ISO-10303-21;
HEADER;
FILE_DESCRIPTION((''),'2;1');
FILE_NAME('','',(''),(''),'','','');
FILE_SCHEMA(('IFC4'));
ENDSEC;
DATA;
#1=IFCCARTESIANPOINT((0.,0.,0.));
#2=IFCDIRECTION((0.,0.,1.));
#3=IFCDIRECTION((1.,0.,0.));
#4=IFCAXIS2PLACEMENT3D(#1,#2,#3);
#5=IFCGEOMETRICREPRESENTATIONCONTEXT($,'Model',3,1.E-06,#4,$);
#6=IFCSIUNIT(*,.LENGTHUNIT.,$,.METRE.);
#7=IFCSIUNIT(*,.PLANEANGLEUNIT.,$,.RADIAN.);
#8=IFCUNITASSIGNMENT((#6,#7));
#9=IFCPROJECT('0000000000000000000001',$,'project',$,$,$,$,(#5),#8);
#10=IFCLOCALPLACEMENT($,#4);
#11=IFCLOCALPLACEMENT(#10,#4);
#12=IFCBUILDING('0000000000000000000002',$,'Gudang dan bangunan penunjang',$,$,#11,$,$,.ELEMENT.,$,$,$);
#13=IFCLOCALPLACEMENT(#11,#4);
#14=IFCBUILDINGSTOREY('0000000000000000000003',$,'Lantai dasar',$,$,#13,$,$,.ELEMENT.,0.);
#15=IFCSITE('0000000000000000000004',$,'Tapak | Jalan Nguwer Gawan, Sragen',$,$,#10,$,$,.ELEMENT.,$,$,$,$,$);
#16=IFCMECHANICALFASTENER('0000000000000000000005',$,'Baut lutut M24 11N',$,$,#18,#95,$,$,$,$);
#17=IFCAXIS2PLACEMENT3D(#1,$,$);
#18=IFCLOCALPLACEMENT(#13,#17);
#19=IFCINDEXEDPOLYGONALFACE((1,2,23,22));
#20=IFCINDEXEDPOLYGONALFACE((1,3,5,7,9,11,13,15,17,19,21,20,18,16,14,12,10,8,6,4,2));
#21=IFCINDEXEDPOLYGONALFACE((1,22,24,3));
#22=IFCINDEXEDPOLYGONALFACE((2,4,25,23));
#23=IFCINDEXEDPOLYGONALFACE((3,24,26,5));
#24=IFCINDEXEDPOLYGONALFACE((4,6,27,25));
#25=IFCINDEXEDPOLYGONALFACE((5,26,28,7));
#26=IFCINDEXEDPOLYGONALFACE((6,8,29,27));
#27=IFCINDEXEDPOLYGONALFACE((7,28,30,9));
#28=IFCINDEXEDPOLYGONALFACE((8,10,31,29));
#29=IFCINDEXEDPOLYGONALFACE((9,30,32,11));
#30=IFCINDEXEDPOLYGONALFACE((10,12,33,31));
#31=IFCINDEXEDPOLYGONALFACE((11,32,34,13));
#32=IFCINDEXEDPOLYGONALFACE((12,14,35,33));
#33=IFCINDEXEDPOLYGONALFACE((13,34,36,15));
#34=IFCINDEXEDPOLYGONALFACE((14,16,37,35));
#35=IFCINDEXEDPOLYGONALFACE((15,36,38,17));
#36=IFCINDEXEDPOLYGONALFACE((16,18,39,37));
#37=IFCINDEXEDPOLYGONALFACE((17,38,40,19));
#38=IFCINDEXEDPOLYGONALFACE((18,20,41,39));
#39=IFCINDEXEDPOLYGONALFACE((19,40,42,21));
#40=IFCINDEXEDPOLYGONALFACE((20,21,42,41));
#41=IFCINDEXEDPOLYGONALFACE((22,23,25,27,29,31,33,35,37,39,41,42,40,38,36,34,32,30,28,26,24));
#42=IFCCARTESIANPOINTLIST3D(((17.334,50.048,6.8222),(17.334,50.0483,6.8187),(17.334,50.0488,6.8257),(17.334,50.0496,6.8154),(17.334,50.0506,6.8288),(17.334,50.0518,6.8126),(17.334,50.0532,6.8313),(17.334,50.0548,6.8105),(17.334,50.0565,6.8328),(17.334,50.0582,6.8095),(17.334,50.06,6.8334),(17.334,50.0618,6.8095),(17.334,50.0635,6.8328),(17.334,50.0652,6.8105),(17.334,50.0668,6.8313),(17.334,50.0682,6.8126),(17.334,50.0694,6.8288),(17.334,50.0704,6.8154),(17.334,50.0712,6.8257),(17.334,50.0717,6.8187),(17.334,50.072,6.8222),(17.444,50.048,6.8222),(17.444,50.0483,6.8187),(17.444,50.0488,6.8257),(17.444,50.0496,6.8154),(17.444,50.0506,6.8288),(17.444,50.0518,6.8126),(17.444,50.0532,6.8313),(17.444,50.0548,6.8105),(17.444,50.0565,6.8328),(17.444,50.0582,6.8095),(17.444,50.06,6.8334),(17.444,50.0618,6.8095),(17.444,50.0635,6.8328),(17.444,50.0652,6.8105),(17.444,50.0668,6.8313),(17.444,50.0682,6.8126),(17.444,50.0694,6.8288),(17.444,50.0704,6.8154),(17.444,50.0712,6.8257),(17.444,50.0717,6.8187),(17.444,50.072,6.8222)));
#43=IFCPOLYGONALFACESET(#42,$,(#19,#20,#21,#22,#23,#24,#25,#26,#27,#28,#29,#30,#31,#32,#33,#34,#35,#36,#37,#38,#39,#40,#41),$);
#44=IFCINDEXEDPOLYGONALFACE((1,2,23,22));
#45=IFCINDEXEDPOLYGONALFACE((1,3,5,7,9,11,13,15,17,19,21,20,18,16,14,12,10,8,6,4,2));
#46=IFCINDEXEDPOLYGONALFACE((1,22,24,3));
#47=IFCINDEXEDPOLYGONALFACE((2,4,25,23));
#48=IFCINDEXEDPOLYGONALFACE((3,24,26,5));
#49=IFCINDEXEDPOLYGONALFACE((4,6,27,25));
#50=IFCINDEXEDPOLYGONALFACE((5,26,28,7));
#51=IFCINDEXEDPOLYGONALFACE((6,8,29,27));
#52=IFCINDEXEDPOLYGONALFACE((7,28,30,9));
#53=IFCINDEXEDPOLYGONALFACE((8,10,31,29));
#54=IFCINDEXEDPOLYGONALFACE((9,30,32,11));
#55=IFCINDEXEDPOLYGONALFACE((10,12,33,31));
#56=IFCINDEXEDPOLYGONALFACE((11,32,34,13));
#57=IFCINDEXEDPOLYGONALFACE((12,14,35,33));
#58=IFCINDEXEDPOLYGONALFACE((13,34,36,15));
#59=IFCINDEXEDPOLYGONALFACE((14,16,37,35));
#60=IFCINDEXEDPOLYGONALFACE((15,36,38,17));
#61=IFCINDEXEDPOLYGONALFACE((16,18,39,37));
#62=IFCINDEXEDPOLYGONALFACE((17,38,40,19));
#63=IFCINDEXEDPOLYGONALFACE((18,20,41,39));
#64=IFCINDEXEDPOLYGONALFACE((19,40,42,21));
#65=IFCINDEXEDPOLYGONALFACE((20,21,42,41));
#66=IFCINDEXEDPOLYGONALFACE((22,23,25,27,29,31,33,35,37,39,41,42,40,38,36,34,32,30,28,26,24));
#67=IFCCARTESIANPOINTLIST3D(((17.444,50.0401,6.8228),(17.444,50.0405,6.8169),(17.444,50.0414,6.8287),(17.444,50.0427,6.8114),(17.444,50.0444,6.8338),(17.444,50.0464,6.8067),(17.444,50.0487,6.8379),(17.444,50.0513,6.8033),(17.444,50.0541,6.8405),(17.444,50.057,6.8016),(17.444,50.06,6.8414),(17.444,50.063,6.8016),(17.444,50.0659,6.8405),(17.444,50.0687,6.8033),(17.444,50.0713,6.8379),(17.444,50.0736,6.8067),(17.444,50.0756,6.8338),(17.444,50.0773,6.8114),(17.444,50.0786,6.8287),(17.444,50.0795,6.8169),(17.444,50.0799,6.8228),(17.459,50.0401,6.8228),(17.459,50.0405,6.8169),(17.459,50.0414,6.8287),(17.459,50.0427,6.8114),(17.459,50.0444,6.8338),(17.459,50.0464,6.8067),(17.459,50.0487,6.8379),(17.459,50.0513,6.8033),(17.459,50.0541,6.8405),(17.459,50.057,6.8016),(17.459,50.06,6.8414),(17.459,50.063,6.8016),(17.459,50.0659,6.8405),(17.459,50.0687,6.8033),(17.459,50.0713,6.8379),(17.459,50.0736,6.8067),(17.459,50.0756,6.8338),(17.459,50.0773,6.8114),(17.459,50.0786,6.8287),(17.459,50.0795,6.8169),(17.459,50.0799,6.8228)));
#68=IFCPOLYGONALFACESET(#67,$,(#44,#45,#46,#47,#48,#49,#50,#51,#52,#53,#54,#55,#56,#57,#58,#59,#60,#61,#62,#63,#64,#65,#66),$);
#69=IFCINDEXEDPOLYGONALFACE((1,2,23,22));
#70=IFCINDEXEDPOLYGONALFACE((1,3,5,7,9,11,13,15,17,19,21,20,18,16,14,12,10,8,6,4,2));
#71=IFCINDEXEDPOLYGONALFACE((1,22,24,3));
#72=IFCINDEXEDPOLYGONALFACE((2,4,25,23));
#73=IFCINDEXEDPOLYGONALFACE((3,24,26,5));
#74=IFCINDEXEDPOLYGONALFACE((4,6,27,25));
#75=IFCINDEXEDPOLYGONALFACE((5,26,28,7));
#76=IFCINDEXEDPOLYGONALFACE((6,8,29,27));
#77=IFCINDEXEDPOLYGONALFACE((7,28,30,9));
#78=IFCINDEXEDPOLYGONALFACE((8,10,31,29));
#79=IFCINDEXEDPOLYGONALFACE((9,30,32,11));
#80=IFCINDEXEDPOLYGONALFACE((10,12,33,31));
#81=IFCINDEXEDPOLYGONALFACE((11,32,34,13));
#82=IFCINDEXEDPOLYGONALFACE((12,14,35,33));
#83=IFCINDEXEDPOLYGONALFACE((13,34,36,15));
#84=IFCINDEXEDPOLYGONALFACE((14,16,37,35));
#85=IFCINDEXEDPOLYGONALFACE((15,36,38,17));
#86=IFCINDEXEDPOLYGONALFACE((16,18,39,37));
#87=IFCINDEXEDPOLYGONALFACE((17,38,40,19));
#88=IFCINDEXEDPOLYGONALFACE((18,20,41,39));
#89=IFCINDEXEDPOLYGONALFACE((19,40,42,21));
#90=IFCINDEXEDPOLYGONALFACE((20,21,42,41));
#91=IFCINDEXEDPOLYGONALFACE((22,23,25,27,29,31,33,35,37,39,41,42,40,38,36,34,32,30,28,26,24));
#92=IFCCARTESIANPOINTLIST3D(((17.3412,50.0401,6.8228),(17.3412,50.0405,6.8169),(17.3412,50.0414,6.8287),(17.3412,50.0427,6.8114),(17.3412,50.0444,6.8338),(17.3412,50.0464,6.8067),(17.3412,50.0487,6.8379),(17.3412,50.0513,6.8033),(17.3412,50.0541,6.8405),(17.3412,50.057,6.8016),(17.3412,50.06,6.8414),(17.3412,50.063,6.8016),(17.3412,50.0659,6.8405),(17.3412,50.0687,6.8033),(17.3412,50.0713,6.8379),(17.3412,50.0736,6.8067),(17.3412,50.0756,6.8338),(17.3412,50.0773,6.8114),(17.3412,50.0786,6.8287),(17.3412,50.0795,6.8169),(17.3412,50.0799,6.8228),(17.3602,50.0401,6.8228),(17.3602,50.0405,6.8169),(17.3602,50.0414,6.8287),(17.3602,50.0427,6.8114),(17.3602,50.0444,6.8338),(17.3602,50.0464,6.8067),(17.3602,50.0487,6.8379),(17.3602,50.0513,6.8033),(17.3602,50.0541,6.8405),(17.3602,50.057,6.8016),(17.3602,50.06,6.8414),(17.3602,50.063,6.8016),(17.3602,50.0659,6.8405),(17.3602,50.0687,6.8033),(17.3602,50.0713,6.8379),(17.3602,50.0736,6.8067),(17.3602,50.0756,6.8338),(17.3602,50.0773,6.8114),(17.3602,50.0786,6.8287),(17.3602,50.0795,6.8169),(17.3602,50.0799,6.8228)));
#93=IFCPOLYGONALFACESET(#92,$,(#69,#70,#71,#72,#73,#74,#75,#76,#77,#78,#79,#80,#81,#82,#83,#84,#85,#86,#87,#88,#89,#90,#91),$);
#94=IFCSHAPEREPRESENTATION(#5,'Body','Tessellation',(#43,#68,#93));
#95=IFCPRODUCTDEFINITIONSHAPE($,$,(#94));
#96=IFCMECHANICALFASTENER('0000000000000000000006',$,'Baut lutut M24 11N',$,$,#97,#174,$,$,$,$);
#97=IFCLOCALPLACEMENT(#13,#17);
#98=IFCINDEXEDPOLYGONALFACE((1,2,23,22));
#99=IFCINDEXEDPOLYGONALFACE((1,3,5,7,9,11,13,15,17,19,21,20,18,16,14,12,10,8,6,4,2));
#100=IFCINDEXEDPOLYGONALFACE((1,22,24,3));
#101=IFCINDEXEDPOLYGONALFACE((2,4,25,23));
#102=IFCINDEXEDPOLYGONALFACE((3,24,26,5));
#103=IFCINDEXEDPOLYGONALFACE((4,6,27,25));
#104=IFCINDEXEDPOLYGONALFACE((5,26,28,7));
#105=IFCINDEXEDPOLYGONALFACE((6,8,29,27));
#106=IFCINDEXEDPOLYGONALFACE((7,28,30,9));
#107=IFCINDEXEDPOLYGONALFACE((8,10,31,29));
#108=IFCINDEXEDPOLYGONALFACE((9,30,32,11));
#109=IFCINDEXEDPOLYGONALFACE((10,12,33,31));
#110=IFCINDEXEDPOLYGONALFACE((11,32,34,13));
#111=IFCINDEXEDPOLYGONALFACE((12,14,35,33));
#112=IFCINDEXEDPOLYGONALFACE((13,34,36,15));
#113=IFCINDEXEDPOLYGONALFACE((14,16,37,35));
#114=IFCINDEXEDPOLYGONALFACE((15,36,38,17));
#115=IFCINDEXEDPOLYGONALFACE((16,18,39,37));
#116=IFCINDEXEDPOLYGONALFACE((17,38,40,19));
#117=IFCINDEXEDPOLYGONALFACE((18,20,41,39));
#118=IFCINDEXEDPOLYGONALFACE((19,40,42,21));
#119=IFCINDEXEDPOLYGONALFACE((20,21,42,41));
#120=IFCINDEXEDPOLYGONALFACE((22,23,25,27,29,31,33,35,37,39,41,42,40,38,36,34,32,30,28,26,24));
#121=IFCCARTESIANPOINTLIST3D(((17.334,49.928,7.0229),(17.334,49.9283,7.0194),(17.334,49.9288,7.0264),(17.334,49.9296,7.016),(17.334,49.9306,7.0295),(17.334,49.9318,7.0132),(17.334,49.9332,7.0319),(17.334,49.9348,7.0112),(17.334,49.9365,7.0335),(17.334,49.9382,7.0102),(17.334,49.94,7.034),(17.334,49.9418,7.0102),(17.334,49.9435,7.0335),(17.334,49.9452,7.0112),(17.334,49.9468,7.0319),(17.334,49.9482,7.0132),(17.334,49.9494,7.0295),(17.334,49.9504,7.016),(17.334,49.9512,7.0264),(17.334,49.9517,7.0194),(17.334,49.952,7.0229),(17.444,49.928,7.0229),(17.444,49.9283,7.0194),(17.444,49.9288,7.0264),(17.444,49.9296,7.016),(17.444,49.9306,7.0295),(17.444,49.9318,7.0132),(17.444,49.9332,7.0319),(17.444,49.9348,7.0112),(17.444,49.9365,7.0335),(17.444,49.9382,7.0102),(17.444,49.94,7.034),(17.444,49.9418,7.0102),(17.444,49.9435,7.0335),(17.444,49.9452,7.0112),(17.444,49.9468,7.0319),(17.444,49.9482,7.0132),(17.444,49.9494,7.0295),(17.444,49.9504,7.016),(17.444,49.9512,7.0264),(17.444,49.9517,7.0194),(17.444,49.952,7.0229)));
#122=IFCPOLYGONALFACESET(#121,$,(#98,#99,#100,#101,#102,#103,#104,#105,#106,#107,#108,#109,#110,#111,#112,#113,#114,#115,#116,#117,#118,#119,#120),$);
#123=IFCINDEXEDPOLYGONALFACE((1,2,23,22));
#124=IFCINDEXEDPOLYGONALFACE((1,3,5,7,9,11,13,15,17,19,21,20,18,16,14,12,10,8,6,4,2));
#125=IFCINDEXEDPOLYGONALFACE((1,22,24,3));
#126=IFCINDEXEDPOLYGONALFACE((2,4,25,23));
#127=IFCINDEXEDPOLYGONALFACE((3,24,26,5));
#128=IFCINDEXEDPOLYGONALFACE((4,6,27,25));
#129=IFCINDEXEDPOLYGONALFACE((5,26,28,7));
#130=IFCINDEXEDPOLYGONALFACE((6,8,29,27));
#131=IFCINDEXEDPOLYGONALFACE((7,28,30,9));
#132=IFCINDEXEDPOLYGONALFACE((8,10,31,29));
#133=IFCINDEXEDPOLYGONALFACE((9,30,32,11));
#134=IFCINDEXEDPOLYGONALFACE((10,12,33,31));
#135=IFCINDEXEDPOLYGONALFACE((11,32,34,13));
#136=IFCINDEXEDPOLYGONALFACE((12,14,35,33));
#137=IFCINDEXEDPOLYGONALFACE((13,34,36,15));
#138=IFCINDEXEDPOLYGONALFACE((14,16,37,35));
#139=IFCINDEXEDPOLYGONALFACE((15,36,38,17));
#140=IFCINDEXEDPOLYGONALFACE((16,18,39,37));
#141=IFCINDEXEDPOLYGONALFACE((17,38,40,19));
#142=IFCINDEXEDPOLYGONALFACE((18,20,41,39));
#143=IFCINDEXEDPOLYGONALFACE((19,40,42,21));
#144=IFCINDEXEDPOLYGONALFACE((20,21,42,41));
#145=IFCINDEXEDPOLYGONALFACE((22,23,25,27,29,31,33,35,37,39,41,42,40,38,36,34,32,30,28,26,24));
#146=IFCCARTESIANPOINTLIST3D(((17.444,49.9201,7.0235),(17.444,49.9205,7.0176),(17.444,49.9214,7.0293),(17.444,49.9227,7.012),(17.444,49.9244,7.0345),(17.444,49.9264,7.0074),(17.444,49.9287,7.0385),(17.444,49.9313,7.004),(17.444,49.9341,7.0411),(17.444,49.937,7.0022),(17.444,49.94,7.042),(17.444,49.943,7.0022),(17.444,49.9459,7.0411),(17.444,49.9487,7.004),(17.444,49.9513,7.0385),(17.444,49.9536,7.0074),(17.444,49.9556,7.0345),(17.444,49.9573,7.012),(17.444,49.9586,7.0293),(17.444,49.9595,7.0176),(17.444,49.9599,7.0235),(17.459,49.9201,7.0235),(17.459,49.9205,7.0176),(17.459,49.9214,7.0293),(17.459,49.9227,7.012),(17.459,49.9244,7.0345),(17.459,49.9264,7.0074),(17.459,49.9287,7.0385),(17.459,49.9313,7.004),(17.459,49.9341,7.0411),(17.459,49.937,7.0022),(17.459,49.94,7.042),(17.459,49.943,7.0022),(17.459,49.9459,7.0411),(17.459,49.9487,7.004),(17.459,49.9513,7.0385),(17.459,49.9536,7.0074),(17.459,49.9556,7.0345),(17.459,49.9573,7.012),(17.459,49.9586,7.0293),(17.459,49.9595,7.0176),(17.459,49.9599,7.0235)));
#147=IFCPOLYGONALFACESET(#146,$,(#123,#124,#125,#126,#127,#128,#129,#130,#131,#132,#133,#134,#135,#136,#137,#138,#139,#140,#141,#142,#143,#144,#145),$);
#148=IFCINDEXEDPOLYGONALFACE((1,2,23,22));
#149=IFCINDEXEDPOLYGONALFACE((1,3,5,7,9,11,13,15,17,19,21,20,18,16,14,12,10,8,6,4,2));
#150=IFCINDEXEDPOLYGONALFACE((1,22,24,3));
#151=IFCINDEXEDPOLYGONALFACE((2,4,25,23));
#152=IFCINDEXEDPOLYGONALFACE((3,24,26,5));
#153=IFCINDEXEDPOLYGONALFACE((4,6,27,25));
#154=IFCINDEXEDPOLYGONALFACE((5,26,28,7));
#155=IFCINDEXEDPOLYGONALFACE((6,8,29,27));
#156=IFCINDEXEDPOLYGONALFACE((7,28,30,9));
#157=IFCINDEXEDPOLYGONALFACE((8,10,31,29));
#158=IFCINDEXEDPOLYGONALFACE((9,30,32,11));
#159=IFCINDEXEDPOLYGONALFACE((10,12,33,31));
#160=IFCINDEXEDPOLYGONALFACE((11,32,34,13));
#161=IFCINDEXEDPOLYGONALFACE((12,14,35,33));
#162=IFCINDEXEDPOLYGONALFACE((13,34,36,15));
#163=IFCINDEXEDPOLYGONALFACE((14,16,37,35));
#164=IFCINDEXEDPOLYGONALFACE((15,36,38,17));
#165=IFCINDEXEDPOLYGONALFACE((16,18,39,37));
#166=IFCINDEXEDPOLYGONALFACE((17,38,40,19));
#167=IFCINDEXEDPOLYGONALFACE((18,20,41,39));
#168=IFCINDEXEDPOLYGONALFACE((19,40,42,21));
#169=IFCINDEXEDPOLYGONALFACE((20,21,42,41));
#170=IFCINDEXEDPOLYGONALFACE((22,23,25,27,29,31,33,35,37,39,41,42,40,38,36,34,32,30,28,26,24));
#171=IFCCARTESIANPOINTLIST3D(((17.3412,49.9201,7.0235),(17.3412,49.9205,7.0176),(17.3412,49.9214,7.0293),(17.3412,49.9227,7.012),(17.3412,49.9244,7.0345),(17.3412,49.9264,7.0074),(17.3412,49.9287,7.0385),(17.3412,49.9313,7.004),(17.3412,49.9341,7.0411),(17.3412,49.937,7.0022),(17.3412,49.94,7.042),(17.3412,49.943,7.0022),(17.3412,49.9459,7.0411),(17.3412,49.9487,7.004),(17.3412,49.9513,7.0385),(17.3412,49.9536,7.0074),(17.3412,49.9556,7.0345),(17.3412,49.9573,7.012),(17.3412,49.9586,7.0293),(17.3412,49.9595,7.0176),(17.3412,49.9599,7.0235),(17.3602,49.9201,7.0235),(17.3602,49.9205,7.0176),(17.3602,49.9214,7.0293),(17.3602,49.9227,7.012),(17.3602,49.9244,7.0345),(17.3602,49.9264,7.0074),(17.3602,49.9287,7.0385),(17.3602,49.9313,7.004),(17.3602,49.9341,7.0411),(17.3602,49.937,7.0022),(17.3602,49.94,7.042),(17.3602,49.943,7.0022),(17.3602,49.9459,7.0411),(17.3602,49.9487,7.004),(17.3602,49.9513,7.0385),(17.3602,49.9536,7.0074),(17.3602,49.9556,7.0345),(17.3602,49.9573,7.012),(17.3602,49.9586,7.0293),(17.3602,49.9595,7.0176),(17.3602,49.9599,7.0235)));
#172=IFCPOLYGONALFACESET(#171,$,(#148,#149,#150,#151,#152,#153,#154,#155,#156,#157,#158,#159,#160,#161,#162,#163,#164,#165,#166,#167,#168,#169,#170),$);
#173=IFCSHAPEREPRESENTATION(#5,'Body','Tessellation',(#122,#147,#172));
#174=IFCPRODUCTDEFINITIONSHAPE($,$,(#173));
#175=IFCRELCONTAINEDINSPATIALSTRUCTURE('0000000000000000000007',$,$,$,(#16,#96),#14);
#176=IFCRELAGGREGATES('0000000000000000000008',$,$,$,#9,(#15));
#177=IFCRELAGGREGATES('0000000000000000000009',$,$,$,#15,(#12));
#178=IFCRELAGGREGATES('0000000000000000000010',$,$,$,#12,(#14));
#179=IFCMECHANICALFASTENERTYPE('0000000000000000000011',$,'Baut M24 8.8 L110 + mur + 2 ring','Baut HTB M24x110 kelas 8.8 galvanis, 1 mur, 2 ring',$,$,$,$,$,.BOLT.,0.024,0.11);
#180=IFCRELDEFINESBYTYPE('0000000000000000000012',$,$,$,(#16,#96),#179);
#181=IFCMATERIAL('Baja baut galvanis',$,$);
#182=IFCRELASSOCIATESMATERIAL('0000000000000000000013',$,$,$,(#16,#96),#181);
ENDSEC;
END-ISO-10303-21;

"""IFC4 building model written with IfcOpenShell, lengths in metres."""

from ifc_helpers import new_model, si_unit, frame, origin_with_axes, place, context, project, spatial, circle, extrude, source, transform, mapped, material, type_object, type_shapes, element, save


model = new_model("IFC4")

# Units and contexts
model_context = context("Model", 3, precision=1e-06, world=origin_with_axes())
ifc_project = project(units=[si_unit("LENGTHUNIT", "METRE"), si_unit("PLANEANGLEUNIT", "RADIAN")], contexts=[model_context])

# Site, building, storey
site_placement = place(None, origin_with_axes())
site = spatial("IfcSite", under=ifc_project, at=site_placement, Name="Tapak | Jalan Nguwer Gawan, Sragen", CompositionType="ELEMENT")
building_placement = place(site_placement, origin_with_axes())
building = spatial("IfcBuilding", under=site, at=building_placement, Name="Gudang dan bangunan penunjang", CompositionType="ELEMENT")
storey_placement = place(building_placement, origin_with_axes())
storey = spatial("IfcBuildingStorey", under=building, at=storey_placement, Name="Lantai dasar", CompositionType="ELEMENT", Elevation=0.0)

# Shared definitions
placement = place(None, origin_with_axes())

# Mechanical fasteners
ifc_material_1 = material(Name="Baja baut galvanis")
mechanical_fastener_type_1 = type_object("IfcMechanicalFastenerType", Name="Baut M24 8.8 L110 + mur + 2 ring", Description="Baut HTB M24x110 kelas 8.8 galvanis, 1 mur, 2 ring", NominalDiameter=0.024, NominalLength=0.11, PredefinedType="BOLT")
shared_shape_1 = source(origin_with_axes(), model_context, "Body", "SweptSolid", [
    extrude(circle(Radius=0.012), origin_with_axes(), (0.0, 0.0, 1.0), 0.11),
    extrude(circle(Radius=0.02), frame((0.0, 0.0, -0.015), z_axis=(0.0, 0.0, 1.0), x_axis=(1.0, 0.0, 0.0)), (0.0, 0.0, 1.0), 0.015),
    extrude(circle(Radius=0.02), frame((0.0, 0.0, 0.0838), z_axis=(0.0, 0.0, 1.0), x_axis=(1.0, 0.0, 0.0)), (0.0, 0.0, 1.0), 0.019),
])
type_shapes(mechanical_fastener_type_1, [shared_shape_1])
element("IfcMechanicalFastener", 1, at=placement, inside=storey, type_object=mechanical_fastener_type_1, material=ifc_material_1, Name="Baut lutut M24 11N", context=model_context, shape_type="MappedRepresentation", body=[
    mapped(shared_shape_1, transform((17.444, 50.06, 6.8213), x_axis=(0.0, 0.0, 1.0), y_axis=(0.0, 1.0, 0.0), z_axis=(-1.0, 0.0, 0.0), scale=1.0)),
])
element("IfcMechanicalFastener", 2, at=placement, inside=storey, type_object=mechanical_fastener_type_1, material=ifc_material_1, Name="Baut lutut M24 11N", context=model_context, shape_type="MappedRepresentation", body=[
    mapped(shared_shape_1, transform((17.444, 49.94, 7.022), x_axis=(0.0, 0.0, 1.0), y_axis=(0.0, 1.0, 0.0), z_axis=(-1.0, 0.0, 0.0), scale=1.0)),
])

save(model, "model.ifc")
